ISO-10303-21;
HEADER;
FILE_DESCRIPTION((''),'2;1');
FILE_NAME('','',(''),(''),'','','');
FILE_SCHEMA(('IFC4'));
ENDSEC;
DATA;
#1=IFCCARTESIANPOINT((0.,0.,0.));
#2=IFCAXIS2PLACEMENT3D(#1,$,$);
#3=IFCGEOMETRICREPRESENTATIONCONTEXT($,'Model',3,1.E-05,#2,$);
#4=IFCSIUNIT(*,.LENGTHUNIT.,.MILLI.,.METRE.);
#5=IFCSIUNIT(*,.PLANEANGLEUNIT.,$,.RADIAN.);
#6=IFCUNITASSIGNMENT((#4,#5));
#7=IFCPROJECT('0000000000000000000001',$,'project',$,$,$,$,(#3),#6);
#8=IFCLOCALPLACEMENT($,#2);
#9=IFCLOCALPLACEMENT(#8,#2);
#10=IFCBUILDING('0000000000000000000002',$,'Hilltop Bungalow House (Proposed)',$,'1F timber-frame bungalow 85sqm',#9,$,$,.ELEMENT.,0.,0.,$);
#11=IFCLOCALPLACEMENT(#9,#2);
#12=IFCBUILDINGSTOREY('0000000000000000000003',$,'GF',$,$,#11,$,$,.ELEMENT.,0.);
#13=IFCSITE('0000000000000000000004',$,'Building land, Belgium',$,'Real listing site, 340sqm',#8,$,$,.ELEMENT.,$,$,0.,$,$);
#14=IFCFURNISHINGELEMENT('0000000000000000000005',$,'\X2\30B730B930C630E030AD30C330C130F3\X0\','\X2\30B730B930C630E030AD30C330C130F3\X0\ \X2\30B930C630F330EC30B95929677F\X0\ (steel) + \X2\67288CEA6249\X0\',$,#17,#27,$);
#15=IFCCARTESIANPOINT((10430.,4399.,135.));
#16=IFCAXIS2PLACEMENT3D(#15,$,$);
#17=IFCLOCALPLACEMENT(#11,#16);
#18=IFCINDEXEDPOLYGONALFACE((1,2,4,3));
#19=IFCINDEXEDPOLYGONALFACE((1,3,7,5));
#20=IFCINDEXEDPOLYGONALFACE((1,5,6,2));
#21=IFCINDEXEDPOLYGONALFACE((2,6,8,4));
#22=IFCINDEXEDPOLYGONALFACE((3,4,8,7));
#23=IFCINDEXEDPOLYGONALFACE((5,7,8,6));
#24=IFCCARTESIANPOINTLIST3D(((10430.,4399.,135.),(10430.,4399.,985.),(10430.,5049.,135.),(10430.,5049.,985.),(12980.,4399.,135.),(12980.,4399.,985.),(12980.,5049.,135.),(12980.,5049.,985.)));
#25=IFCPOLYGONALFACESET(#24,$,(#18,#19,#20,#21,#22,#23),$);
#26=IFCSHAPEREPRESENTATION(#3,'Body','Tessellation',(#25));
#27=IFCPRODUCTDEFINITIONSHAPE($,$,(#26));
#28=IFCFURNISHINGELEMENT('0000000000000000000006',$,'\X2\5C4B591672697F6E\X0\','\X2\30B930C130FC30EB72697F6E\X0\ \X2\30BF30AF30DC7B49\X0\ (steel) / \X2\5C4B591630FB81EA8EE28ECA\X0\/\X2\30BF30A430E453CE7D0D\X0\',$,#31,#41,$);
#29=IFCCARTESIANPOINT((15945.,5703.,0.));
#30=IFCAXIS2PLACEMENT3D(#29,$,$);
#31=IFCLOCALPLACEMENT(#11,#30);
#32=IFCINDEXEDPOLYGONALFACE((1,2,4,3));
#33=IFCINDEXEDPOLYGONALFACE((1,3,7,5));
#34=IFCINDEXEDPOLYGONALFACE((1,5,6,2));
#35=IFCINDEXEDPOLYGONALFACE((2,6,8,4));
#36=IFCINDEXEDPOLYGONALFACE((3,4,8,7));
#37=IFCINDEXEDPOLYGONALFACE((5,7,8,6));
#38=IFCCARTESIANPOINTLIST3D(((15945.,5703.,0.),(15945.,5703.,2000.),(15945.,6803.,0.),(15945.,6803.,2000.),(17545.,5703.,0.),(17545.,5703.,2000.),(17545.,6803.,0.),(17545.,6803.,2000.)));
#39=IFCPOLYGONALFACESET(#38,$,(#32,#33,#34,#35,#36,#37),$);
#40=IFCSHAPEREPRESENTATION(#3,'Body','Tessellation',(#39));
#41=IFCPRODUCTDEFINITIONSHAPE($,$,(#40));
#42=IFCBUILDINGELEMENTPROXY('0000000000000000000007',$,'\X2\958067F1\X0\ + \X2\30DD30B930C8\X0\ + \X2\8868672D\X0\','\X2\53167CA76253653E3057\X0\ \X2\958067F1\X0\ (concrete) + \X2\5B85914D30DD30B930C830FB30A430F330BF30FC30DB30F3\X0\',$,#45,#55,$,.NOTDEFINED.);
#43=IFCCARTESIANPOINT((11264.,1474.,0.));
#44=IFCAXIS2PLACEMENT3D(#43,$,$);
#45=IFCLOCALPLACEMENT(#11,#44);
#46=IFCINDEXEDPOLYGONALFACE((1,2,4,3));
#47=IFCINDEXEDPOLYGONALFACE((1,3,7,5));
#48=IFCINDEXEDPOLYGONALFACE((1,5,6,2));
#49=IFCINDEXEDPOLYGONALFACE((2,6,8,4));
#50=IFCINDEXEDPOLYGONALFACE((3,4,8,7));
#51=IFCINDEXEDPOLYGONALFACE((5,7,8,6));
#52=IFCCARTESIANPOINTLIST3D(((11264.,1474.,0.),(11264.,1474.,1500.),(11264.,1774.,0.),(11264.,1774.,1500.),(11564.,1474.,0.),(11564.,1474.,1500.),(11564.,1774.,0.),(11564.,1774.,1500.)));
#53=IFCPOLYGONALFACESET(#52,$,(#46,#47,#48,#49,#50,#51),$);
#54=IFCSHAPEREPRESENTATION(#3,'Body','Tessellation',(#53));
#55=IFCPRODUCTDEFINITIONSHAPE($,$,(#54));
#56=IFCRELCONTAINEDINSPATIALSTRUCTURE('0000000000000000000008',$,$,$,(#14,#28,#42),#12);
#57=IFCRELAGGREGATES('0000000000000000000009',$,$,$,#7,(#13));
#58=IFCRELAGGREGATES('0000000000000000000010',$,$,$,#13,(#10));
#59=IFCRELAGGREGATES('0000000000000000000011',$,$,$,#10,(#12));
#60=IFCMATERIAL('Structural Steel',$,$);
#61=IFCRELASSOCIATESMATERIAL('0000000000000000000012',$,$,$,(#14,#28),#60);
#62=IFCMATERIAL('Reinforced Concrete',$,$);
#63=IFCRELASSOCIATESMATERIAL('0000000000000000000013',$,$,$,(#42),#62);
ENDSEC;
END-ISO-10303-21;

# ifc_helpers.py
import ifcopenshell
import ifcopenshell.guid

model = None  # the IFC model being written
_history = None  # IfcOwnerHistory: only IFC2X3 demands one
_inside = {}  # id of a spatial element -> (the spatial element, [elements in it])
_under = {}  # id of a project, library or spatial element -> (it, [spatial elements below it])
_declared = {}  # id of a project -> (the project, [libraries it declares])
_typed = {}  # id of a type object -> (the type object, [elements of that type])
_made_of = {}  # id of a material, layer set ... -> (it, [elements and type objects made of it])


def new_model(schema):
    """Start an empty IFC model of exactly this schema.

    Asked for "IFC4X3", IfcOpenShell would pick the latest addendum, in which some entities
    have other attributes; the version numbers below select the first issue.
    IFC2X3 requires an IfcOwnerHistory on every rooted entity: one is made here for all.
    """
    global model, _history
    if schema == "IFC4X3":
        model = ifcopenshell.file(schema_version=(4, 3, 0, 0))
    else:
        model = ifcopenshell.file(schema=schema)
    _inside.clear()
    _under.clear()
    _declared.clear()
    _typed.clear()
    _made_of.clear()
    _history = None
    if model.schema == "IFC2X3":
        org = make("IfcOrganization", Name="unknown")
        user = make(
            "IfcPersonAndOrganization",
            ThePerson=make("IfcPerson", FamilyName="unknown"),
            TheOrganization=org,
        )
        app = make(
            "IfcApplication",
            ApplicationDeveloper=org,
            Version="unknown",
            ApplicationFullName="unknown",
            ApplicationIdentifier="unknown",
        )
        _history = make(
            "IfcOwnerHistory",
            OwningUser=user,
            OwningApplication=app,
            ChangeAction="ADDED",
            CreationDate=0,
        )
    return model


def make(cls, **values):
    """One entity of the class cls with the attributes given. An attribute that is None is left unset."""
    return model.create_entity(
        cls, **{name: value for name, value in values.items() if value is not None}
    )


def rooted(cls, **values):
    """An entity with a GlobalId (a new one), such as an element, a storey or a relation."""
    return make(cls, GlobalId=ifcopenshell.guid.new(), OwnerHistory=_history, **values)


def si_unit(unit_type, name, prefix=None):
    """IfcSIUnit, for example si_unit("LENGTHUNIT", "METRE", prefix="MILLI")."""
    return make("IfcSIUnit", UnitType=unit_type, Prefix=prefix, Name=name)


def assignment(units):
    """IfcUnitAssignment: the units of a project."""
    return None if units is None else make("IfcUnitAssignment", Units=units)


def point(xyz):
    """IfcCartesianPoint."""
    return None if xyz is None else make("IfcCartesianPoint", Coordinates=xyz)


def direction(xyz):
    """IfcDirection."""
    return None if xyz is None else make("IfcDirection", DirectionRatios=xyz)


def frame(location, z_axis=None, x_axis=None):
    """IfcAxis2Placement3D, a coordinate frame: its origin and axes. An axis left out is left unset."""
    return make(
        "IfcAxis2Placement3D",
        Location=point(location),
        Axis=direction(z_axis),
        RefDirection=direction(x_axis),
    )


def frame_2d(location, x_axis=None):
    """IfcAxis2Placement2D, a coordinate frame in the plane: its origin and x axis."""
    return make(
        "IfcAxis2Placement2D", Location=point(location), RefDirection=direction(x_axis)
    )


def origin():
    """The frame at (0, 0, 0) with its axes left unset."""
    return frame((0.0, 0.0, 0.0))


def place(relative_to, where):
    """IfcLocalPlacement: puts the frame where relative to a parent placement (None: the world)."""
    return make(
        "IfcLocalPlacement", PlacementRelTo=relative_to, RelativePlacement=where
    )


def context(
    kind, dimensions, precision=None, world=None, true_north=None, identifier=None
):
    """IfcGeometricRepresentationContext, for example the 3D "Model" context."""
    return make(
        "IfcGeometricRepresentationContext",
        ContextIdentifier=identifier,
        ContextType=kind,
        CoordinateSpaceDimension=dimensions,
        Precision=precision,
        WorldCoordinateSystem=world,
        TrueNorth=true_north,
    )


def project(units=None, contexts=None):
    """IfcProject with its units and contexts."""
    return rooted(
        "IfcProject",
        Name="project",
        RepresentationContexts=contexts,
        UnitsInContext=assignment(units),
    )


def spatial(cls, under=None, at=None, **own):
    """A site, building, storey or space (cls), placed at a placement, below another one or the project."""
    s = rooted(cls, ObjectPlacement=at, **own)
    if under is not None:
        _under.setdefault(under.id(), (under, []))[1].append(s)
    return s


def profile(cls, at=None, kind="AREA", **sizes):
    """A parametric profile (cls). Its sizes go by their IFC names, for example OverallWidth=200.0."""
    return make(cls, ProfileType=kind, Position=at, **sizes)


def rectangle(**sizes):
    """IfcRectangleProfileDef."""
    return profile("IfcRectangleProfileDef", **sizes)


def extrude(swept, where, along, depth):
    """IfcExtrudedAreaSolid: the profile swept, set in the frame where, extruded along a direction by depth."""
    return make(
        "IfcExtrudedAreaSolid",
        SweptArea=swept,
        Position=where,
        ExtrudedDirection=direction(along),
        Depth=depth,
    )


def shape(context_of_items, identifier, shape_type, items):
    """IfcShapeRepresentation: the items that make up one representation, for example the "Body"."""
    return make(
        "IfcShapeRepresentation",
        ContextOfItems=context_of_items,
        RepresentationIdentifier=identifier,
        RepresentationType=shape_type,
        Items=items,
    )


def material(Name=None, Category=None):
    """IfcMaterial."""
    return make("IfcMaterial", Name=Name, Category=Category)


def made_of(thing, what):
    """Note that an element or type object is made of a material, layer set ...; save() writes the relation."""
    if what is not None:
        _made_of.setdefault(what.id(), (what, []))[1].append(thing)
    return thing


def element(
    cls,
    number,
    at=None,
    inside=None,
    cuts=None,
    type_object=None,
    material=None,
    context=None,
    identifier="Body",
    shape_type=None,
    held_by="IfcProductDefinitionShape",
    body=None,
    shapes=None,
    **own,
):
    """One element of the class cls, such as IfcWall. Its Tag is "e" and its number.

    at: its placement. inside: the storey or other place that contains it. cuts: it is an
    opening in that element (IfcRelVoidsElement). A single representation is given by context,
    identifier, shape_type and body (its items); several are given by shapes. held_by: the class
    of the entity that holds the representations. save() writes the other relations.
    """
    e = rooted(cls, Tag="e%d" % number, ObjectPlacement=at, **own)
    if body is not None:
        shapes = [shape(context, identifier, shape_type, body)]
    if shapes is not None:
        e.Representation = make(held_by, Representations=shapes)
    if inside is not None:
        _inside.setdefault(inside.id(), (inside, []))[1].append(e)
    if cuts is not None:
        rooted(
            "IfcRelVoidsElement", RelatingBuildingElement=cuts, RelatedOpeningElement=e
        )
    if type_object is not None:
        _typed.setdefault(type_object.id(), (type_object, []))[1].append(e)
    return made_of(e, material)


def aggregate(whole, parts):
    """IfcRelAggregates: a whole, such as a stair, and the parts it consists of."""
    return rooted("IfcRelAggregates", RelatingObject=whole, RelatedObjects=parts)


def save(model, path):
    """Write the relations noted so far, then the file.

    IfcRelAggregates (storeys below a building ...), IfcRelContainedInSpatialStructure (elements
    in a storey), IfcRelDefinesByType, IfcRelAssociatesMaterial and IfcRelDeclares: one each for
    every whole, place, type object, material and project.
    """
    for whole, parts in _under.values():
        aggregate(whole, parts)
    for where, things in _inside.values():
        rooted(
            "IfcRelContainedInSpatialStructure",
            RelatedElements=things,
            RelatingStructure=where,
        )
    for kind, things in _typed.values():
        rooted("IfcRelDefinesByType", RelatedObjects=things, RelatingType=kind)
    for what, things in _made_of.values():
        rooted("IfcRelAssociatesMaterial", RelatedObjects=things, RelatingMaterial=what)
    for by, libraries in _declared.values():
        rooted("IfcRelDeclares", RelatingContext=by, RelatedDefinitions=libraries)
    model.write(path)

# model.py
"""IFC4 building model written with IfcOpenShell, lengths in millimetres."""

from ifc_helpers import new_model, si_unit, frame, frame_2d, origin, place, context, project, spatial, rectangle, extrude, material, element, save


model = new_model("IFC4")

# Units and contexts
model_context = context("Model", 3, precision=1e-05, world=origin())
ifc_project = project(units=[si_unit("LENGTHUNIT", "METRE", prefix="MILLI"), si_unit("PLANEANGLEUNIT", "RADIAN")], contexts=[model_context])

# Site, building, storey
site_placement = place(None, origin())
site = spatial("IfcSite", under=ifc_project, at=site_placement, Name="Building land, Belgium", ObjectType="Real listing site, 340sqm", CompositionType="ELEMENT", RefElevation=0.0)
building_placement = place(site_placement, origin())
building = spatial("IfcBuilding", under=site, at=building_placement, Name="Hilltop Bungalow House (Proposed)", ObjectType="1F timber-frame bungalow 85sqm", CompositionType="ELEMENT", ElevationOfRefHeight=0.0, ElevationOfTerrain=0.0)
storey_placement = place(building_placement, origin())
storey = spatial("IfcBuildingStorey", under=building, at=storey_placement, Name="GF", CompositionType="ELEMENT", Elevation=0.0)

# Shared definitions
ifc_material_1 = material(Name="Reinforced Concrete")

# Shared definitions
ifc_material_2 = material(Name="Structural Steel")

# Furnishing elements
furnishing_1_placement = place(storey_placement, frame((10430.0, 4399.0, 135.0)))
element("IfcFurnishingElement", 1, at=furnishing_1_placement, inside=storey, material=ifc_material_2, Name="システムキッチン", Description="システムキッチン ステンレス天板 (steel) + 木質扉", context=model_context, shape_type="SweptSolid", body=[
    extrude(rectangle(XDim=2550.0, YDim=650.0, at=frame_2d((1275.0, 325.0))), frame((10430.0, 4399.0, 135.0)), (0.0, 0.0, 1.0), 850.0),
])
furnishing_2_placement = place(storey_placement, frame((15945.0, 5703.0, 0.0)))
element("IfcFurnishingElement", 2, at=furnishing_2_placement, inside=storey, material=ifc_material_2, Name="屋外物置", Description="スチール物置 タクボ等 (steel) / 屋外・自転車/タイヤ収納", context=model_context, shape_type="SweptSolid", body=[
    extrude(rectangle(XDim=1600.0, YDim=1100.0, at=frame_2d((800.0, 550.0))), frame((15945.0, 5703.0, 0.0)), (0.0, 0.0, 1.0), 2000.0),
])

# Building element proxy
proxy_placement = place(storey_placement, frame((11264.0, 1474.0, 0.0)))
element("IfcBuildingElementProxy", 3, at=proxy_placement, inside=storey, material=ifc_material_1, Name="門柱 + ポスト + 表札", Description="化粧打放し 門柱 (concrete) + 宅配ポスト・インターホン", PredefinedType="NOTDEFINED", context=model_context, shape_type="SweptSolid", body=[
    extrude(rectangle(XDim=300.0, YDim=300.0, at=frame_2d((150.0, 150.0))), frame((11264.0, 1474.0, 0.0)), (0.0, 0.0, 1.0), 1500.0),
])

save(model, "model.ifc")
